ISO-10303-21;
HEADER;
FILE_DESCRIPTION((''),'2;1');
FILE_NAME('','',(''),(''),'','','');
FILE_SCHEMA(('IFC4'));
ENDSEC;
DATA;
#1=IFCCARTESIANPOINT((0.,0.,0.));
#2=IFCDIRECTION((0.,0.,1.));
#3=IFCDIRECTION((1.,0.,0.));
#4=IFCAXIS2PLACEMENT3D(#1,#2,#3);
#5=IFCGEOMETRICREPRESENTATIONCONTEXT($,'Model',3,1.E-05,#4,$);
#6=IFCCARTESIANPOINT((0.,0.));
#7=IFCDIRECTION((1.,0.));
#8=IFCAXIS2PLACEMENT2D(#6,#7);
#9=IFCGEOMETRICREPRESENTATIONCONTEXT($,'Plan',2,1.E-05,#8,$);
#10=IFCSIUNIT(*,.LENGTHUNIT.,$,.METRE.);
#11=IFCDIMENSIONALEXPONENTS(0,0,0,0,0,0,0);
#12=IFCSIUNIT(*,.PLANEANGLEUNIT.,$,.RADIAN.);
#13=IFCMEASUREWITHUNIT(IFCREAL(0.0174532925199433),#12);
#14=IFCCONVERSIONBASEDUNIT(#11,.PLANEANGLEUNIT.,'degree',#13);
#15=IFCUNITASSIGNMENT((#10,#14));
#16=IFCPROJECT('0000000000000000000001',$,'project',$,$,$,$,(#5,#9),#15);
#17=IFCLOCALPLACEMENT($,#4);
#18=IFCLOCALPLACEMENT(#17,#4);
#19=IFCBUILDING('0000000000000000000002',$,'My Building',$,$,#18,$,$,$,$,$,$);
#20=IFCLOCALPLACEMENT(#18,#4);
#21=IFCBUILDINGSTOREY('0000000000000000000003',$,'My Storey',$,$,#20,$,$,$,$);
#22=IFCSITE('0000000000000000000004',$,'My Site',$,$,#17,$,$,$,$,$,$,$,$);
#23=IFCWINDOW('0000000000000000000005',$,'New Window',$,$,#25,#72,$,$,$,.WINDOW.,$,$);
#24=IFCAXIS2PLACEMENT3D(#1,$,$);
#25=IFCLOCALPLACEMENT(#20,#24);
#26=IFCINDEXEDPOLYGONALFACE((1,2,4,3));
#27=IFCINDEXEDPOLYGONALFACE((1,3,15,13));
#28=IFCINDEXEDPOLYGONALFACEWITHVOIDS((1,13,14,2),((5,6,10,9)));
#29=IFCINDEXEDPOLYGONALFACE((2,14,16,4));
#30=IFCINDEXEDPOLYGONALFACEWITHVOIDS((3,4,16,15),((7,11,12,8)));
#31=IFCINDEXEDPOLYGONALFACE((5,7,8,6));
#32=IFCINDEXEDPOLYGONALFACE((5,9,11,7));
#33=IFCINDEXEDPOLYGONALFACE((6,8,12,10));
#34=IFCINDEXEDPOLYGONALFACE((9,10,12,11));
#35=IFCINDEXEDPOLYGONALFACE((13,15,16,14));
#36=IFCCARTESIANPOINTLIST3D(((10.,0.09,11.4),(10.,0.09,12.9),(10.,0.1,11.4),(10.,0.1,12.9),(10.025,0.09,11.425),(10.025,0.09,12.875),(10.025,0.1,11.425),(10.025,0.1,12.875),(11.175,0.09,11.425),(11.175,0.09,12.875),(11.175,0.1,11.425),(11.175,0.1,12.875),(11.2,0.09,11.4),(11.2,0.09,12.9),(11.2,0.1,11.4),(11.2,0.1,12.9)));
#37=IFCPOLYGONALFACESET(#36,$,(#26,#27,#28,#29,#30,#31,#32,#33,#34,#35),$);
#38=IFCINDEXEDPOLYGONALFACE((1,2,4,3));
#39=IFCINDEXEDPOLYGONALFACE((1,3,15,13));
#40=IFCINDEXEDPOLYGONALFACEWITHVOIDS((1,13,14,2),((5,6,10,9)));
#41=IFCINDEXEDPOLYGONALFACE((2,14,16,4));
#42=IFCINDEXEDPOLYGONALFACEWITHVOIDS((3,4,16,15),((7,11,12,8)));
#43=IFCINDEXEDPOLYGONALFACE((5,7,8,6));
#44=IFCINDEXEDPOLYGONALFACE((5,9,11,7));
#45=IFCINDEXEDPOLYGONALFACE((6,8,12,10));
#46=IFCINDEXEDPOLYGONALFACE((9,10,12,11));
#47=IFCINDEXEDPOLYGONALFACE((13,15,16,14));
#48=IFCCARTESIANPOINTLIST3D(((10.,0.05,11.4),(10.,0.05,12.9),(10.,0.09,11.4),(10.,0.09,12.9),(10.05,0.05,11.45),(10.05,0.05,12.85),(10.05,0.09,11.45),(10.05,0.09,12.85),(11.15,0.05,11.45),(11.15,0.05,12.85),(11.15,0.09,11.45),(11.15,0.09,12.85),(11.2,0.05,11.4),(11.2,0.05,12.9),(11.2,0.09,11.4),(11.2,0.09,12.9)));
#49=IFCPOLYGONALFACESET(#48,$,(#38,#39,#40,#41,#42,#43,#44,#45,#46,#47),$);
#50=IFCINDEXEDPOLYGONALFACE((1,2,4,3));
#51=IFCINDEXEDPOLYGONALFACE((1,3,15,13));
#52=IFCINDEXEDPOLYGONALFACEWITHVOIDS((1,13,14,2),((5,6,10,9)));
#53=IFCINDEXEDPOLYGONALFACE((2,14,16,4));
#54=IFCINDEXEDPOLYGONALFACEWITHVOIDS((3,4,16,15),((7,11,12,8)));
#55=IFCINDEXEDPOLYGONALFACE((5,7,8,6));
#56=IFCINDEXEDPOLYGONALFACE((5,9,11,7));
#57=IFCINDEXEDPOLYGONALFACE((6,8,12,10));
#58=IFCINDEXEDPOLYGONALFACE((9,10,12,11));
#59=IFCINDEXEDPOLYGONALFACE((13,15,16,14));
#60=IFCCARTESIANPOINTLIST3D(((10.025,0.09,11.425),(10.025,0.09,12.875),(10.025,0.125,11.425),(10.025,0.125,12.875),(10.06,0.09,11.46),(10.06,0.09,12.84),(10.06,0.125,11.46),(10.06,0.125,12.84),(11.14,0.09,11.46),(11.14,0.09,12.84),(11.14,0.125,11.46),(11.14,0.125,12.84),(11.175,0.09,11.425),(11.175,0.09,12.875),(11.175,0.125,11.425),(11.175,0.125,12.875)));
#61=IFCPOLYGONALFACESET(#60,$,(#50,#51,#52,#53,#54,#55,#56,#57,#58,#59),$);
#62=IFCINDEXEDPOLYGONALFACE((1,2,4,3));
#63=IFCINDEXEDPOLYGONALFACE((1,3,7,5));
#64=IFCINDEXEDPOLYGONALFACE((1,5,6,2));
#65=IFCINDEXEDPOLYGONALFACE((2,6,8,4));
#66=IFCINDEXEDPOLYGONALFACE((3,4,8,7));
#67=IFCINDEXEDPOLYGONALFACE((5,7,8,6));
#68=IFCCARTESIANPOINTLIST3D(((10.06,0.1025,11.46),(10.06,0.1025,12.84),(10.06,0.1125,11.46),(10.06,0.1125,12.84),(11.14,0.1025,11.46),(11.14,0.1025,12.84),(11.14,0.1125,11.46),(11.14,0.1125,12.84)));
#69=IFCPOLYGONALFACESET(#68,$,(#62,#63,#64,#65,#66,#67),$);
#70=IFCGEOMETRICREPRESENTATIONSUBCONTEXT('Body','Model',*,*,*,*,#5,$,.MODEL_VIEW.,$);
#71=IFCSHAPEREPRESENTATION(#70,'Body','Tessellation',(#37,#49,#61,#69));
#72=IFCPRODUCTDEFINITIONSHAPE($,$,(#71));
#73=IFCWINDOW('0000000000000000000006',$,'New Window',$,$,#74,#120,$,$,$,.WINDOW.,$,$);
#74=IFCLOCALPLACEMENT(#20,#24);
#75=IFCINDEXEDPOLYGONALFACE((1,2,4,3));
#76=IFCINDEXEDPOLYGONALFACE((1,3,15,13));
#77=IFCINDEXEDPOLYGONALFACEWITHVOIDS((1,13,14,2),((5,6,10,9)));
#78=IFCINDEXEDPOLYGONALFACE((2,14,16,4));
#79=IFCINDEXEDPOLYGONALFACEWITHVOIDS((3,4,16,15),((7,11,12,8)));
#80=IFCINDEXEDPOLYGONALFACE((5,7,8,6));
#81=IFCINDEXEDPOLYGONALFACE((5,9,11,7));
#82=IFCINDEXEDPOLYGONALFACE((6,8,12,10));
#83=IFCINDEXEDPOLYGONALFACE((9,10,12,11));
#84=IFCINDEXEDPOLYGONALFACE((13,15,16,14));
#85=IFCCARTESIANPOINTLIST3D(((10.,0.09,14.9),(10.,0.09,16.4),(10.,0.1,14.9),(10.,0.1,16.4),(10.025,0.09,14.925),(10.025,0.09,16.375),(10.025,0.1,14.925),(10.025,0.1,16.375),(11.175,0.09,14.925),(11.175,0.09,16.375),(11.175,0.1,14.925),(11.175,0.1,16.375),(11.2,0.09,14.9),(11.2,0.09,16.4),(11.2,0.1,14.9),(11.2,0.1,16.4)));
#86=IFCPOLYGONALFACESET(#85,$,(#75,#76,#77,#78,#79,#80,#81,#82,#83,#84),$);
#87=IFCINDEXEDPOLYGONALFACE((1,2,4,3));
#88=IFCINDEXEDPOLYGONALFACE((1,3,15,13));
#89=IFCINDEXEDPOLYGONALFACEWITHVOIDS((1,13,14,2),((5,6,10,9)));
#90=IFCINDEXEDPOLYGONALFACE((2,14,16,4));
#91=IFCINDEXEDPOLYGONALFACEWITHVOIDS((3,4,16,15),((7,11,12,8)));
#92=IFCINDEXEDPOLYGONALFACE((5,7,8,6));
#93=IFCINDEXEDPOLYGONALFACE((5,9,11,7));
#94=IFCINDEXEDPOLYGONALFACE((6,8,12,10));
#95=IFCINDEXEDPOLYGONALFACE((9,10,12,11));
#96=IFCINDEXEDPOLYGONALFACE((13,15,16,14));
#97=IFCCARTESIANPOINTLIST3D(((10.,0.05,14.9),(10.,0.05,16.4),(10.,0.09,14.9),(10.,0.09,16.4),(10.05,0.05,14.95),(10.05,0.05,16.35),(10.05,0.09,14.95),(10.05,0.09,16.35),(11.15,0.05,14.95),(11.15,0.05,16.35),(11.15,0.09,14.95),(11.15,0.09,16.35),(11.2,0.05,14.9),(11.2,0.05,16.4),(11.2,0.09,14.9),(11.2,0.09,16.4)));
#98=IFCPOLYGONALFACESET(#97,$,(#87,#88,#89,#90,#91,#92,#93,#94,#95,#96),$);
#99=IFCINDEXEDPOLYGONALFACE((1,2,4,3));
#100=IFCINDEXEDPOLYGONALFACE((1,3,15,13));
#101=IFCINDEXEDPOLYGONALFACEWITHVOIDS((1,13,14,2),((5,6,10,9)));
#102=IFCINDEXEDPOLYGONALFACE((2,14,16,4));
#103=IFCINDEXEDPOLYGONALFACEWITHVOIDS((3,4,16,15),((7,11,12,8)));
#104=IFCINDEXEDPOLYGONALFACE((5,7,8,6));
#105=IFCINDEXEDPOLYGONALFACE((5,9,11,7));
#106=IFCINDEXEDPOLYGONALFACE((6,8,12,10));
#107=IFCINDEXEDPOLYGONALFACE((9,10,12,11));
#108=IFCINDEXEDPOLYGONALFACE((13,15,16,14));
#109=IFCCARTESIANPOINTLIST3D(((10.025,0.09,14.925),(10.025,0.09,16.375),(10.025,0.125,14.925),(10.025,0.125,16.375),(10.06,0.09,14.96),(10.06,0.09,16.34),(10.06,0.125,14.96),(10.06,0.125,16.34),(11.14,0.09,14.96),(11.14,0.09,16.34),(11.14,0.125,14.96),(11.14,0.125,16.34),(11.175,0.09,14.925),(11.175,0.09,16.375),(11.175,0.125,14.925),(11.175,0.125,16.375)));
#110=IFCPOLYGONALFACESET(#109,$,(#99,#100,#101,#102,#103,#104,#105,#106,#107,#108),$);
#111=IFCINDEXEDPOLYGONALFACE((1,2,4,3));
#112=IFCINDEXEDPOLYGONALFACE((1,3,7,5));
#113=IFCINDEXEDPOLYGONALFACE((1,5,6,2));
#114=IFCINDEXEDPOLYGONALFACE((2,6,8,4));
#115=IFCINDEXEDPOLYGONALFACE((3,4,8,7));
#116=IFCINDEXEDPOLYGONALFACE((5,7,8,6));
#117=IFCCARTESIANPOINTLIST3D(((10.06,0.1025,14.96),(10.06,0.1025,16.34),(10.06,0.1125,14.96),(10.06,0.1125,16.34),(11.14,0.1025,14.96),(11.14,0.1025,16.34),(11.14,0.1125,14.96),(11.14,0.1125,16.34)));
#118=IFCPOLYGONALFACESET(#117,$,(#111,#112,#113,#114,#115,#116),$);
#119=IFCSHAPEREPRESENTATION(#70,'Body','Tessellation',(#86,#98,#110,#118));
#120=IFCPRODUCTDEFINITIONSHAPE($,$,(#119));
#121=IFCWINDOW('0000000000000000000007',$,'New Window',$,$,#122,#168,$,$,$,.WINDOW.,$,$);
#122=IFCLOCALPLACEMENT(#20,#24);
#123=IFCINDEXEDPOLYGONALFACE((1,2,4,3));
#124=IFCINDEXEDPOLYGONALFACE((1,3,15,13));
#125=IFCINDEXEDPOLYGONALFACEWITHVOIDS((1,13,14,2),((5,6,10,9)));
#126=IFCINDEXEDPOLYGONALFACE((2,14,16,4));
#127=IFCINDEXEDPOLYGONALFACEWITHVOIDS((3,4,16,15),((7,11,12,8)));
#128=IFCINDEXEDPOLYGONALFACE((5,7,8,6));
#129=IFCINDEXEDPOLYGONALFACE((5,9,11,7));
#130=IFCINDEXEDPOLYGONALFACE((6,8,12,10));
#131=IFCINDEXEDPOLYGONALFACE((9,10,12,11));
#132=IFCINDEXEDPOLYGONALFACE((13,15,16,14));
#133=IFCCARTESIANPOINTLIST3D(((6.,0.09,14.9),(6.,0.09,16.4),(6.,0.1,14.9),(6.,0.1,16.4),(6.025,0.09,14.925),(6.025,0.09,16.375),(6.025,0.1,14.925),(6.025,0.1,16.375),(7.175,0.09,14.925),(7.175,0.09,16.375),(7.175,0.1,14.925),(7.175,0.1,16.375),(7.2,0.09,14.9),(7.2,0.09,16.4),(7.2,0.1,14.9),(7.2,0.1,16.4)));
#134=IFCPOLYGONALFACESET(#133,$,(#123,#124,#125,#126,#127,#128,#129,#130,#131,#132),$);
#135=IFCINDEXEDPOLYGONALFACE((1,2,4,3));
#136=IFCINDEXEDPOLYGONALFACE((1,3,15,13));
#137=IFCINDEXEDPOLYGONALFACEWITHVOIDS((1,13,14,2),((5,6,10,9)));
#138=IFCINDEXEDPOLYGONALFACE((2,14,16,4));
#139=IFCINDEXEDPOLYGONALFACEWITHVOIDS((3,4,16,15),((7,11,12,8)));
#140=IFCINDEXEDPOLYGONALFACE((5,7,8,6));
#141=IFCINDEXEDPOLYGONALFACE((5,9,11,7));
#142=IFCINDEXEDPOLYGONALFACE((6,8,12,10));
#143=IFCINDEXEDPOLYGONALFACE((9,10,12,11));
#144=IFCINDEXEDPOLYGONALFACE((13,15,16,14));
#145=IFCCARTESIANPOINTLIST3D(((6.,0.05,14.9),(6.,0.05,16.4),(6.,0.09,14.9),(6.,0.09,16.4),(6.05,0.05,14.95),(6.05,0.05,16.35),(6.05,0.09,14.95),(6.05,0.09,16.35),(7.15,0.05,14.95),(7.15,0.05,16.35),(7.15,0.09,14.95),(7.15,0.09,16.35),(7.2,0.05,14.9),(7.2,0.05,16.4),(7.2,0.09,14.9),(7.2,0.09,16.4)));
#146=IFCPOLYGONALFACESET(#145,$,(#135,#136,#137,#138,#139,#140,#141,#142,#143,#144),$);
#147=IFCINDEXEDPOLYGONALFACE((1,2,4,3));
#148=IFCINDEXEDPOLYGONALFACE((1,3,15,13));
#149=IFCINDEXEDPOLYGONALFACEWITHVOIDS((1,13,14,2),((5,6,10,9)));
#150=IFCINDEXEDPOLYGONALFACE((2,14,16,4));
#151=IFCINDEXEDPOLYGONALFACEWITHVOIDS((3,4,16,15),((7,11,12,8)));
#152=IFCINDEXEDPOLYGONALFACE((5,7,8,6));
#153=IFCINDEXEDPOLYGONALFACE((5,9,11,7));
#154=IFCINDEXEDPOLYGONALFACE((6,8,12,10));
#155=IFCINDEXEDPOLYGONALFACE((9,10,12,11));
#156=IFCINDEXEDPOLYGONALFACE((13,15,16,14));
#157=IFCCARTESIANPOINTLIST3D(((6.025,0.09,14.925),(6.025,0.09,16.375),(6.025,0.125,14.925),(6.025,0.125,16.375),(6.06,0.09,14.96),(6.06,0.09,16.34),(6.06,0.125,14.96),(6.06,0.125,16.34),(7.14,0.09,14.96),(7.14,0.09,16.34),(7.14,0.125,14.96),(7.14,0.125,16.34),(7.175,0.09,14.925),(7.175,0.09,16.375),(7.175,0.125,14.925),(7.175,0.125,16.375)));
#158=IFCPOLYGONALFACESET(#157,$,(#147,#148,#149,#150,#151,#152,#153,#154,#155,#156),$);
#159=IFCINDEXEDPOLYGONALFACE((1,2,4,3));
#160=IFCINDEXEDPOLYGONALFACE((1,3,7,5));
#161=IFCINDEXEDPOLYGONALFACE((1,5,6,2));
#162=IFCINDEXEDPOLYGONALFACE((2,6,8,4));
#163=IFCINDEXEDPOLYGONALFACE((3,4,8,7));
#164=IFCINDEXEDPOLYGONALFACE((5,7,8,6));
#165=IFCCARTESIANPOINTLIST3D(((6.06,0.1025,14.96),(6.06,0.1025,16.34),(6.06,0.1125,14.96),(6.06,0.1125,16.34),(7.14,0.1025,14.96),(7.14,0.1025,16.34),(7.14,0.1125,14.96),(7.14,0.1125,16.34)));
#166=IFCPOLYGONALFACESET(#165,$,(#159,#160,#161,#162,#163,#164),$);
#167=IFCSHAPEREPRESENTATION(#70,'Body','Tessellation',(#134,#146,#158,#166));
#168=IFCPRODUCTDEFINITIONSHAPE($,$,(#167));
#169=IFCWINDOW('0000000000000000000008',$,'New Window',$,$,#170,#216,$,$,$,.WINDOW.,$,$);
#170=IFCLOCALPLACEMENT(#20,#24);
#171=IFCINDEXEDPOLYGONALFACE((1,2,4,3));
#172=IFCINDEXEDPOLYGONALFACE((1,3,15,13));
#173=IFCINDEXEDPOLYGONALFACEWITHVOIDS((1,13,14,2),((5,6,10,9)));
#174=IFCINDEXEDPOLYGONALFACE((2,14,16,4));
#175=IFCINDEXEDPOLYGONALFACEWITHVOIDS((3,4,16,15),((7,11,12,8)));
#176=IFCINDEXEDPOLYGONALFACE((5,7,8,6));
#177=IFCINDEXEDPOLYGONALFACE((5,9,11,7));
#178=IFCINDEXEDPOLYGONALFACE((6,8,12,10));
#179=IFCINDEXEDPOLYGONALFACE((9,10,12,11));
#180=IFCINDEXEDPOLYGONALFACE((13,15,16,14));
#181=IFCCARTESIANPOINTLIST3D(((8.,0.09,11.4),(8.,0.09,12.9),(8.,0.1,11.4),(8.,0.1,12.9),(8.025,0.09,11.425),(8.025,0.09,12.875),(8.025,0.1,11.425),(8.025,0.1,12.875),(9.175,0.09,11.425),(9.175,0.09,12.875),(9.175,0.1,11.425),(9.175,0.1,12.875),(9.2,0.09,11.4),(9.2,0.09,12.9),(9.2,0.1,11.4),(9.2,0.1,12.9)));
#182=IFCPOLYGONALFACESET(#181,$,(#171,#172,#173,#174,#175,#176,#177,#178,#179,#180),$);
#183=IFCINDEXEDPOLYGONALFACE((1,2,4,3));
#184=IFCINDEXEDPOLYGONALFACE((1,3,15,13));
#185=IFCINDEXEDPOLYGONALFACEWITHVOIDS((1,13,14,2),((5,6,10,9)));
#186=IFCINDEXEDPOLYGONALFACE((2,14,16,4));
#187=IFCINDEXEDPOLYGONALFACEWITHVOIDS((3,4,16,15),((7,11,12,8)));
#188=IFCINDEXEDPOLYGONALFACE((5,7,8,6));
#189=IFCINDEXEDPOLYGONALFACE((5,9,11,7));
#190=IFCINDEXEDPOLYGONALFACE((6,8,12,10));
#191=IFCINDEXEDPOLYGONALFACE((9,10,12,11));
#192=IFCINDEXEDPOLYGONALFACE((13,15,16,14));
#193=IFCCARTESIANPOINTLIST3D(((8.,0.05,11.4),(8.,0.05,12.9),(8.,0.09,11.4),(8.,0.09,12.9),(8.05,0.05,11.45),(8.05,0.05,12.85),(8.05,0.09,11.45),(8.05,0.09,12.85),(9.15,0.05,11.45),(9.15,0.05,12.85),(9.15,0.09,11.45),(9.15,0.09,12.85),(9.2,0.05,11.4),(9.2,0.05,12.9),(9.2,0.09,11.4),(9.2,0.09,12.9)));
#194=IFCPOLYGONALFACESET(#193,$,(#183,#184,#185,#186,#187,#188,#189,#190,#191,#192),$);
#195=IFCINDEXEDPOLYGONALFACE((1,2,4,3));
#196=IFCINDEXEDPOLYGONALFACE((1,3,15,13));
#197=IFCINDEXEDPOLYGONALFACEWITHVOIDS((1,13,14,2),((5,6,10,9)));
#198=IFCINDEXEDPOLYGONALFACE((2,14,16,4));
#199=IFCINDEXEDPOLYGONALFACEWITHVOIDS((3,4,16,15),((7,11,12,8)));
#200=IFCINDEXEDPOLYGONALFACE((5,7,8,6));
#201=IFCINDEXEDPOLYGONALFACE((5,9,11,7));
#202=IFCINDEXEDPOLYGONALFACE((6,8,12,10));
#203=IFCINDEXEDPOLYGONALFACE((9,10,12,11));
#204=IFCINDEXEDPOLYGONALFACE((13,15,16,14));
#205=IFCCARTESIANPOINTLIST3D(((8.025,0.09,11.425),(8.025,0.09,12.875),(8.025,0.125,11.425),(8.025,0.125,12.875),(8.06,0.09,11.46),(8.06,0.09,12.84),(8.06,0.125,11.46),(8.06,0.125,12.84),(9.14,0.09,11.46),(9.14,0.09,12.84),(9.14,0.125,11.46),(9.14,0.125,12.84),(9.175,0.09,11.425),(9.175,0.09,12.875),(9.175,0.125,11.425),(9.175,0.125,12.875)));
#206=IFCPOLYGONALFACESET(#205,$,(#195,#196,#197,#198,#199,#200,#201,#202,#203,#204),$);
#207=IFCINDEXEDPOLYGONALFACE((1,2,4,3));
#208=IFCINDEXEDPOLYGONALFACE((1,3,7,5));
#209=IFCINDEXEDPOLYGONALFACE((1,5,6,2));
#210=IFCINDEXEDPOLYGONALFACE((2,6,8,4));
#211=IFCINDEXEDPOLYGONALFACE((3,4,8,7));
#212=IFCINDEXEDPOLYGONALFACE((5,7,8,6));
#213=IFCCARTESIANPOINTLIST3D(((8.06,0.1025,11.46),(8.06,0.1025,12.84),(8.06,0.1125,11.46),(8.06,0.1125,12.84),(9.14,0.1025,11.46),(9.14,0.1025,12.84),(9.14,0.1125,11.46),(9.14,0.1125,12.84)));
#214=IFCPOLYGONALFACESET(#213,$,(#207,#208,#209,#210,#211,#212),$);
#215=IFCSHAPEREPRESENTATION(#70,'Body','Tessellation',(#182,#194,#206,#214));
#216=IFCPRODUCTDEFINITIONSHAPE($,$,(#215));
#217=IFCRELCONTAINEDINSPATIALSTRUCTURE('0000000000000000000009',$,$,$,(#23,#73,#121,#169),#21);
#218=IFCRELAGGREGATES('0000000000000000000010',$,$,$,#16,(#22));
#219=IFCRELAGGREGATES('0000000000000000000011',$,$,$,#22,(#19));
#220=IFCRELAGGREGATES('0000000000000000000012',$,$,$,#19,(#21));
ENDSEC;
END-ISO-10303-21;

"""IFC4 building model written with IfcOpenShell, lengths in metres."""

from ifc_helpers import new_model, entity, si_unit, converted_unit, frame, origin_with_axes, origin_2d_with_axis, place, context, subcontext, project, spatial, line, indexed_curve, outline, extrude, element, save


model = new_model("IFC4")

# Units and contexts
model_context = context("Model", 3, precision=1e-05, world=origin_with_axes())
plan_context = context("Plan", 2, precision=1e-05, world=origin_2d_with_axis())
body_context = subcontext(model_context, "Body", "Model", "MODEL_VIEW")
ifc_project = project(units=[si_unit("LENGTHUNIT", "METRE"), converted_unit("PLANEANGLEUNIT", "degree", entity("IfcReal", 0.0174532925199433), si_unit("PLANEANGLEUNIT", "RADIAN"), dimensions=[0, 0, 0, 0, 0, 0, 0])], contexts=[model_context, plan_context])

# Site, building, storey
site_placement = place(None, origin_with_axes())
site = spatial("IfcSite", under=ifc_project, at=site_placement, Name="My Site")
building_placement = place(site_placement, origin_with_axes())
building = spatial("IfcBuilding", under=site, at=building_placement, Name="My Building")
storey_placement = place(building_placement, origin_with_axes())
storey = spatial("IfcBuildingStorey", under=building, at=storey_placement, Name="My Storey")

# Windows
for number, where, z_axis, x_axis, name in (
    (1, (10.0, 0.0, 11.4), (0.0, 0.0, 1.0), (1.0, 0.0, 0.0), "New Window"),
    (2, (10.0, 0.0, 14.9), (0.0, 0.0, 1.0), (1.0, 0.0, 0.0), "New Window"),
    (3, (6.0, 0.0, 14.9), (0.0, 0.0, 1.0), (1.0, 0.0, 0.0), "New Window"),
    (4, (8.0, 0.0, 11.4), (0.0, 0.0, 1.0), (1.0, 0.0, 0.0), "New Window"),
):
    element("IfcWindow", number, at=place(storey_placement, frame(where, z_axis=z_axis, x_axis=x_axis)), inside=storey, Name=name, PredefinedType="WINDOW", context=body_context, shape_type="SweptSolid", body=[
        extrude(outline(indexed_curve([(0.0, 0.0), (1.2, 0.0), (1.2, 1.5), (0.0, 1.5)], segments=[line(1, 2, 3, 4, 1)]), holes=[indexed_curve([(0.025, 0.025), (1.175, 0.025), (1.175, 1.475), (0.025, 1.475)], segments=[line(1, 2, 3, 4, 1)])]), frame((0.0, 0.09, 0.0), z_axis=(0.0, -1.0, 0.0), x_axis=(1.0, 0.0, 0.0)), (0.0, 0.0, -1.0), 0.01),
        extrude(outline(indexed_curve([(0.0, 0.0), (1.2, 0.0), (1.2, 1.5), (0.0, 1.5)], segments=[line(1, 2, 3, 4, 1)]), holes=[indexed_curve([(0.05, 0.05), (1.15, 0.05), (1.15, 1.45), (0.05, 1.45)], segments=[line(1, 2, 3, 4, 1)])]), frame((0.0, 0.05, 0.0), z_axis=(0.0, -1.0, 0.0), x_axis=(1.0, 0.0, 0.0)), (0.0, 0.0, -1.0), 0.04),
        extrude(outline(indexed_curve([(0.0, 0.0), (1.15, 0.0), (1.15, 1.45), (0.0, 1.45)], segments=[line(1, 2, 3, 4, 1)]), holes=[indexed_curve([(0.035, 0.035), (1.115, 0.035), (1.115, 1.415), (0.035, 1.415)], segments=[line(1, 2, 3, 4, 1)])]), frame((0.025, 0.09, 0.025), z_axis=(0.0, -1.0, 0.0), x_axis=(1.0, 0.0, 0.0)), (0.0, 0.0, -1.0), 0.035),
        extrude(outline(indexed_curve([(0.035, 0.035), (1.115, 0.035), (1.115, 1.415), (0.035, 1.415)], segments=[line(1, 2, 3, 4, 1)])), frame((0.025, 0.1025, 0.025), z_axis=(0.0, -1.0, 0.0), x_axis=(1.0, 0.0, 0.0)), (0.0, 0.0, -1.0), 0.01),
    ])

save(model, "model.ifc")
